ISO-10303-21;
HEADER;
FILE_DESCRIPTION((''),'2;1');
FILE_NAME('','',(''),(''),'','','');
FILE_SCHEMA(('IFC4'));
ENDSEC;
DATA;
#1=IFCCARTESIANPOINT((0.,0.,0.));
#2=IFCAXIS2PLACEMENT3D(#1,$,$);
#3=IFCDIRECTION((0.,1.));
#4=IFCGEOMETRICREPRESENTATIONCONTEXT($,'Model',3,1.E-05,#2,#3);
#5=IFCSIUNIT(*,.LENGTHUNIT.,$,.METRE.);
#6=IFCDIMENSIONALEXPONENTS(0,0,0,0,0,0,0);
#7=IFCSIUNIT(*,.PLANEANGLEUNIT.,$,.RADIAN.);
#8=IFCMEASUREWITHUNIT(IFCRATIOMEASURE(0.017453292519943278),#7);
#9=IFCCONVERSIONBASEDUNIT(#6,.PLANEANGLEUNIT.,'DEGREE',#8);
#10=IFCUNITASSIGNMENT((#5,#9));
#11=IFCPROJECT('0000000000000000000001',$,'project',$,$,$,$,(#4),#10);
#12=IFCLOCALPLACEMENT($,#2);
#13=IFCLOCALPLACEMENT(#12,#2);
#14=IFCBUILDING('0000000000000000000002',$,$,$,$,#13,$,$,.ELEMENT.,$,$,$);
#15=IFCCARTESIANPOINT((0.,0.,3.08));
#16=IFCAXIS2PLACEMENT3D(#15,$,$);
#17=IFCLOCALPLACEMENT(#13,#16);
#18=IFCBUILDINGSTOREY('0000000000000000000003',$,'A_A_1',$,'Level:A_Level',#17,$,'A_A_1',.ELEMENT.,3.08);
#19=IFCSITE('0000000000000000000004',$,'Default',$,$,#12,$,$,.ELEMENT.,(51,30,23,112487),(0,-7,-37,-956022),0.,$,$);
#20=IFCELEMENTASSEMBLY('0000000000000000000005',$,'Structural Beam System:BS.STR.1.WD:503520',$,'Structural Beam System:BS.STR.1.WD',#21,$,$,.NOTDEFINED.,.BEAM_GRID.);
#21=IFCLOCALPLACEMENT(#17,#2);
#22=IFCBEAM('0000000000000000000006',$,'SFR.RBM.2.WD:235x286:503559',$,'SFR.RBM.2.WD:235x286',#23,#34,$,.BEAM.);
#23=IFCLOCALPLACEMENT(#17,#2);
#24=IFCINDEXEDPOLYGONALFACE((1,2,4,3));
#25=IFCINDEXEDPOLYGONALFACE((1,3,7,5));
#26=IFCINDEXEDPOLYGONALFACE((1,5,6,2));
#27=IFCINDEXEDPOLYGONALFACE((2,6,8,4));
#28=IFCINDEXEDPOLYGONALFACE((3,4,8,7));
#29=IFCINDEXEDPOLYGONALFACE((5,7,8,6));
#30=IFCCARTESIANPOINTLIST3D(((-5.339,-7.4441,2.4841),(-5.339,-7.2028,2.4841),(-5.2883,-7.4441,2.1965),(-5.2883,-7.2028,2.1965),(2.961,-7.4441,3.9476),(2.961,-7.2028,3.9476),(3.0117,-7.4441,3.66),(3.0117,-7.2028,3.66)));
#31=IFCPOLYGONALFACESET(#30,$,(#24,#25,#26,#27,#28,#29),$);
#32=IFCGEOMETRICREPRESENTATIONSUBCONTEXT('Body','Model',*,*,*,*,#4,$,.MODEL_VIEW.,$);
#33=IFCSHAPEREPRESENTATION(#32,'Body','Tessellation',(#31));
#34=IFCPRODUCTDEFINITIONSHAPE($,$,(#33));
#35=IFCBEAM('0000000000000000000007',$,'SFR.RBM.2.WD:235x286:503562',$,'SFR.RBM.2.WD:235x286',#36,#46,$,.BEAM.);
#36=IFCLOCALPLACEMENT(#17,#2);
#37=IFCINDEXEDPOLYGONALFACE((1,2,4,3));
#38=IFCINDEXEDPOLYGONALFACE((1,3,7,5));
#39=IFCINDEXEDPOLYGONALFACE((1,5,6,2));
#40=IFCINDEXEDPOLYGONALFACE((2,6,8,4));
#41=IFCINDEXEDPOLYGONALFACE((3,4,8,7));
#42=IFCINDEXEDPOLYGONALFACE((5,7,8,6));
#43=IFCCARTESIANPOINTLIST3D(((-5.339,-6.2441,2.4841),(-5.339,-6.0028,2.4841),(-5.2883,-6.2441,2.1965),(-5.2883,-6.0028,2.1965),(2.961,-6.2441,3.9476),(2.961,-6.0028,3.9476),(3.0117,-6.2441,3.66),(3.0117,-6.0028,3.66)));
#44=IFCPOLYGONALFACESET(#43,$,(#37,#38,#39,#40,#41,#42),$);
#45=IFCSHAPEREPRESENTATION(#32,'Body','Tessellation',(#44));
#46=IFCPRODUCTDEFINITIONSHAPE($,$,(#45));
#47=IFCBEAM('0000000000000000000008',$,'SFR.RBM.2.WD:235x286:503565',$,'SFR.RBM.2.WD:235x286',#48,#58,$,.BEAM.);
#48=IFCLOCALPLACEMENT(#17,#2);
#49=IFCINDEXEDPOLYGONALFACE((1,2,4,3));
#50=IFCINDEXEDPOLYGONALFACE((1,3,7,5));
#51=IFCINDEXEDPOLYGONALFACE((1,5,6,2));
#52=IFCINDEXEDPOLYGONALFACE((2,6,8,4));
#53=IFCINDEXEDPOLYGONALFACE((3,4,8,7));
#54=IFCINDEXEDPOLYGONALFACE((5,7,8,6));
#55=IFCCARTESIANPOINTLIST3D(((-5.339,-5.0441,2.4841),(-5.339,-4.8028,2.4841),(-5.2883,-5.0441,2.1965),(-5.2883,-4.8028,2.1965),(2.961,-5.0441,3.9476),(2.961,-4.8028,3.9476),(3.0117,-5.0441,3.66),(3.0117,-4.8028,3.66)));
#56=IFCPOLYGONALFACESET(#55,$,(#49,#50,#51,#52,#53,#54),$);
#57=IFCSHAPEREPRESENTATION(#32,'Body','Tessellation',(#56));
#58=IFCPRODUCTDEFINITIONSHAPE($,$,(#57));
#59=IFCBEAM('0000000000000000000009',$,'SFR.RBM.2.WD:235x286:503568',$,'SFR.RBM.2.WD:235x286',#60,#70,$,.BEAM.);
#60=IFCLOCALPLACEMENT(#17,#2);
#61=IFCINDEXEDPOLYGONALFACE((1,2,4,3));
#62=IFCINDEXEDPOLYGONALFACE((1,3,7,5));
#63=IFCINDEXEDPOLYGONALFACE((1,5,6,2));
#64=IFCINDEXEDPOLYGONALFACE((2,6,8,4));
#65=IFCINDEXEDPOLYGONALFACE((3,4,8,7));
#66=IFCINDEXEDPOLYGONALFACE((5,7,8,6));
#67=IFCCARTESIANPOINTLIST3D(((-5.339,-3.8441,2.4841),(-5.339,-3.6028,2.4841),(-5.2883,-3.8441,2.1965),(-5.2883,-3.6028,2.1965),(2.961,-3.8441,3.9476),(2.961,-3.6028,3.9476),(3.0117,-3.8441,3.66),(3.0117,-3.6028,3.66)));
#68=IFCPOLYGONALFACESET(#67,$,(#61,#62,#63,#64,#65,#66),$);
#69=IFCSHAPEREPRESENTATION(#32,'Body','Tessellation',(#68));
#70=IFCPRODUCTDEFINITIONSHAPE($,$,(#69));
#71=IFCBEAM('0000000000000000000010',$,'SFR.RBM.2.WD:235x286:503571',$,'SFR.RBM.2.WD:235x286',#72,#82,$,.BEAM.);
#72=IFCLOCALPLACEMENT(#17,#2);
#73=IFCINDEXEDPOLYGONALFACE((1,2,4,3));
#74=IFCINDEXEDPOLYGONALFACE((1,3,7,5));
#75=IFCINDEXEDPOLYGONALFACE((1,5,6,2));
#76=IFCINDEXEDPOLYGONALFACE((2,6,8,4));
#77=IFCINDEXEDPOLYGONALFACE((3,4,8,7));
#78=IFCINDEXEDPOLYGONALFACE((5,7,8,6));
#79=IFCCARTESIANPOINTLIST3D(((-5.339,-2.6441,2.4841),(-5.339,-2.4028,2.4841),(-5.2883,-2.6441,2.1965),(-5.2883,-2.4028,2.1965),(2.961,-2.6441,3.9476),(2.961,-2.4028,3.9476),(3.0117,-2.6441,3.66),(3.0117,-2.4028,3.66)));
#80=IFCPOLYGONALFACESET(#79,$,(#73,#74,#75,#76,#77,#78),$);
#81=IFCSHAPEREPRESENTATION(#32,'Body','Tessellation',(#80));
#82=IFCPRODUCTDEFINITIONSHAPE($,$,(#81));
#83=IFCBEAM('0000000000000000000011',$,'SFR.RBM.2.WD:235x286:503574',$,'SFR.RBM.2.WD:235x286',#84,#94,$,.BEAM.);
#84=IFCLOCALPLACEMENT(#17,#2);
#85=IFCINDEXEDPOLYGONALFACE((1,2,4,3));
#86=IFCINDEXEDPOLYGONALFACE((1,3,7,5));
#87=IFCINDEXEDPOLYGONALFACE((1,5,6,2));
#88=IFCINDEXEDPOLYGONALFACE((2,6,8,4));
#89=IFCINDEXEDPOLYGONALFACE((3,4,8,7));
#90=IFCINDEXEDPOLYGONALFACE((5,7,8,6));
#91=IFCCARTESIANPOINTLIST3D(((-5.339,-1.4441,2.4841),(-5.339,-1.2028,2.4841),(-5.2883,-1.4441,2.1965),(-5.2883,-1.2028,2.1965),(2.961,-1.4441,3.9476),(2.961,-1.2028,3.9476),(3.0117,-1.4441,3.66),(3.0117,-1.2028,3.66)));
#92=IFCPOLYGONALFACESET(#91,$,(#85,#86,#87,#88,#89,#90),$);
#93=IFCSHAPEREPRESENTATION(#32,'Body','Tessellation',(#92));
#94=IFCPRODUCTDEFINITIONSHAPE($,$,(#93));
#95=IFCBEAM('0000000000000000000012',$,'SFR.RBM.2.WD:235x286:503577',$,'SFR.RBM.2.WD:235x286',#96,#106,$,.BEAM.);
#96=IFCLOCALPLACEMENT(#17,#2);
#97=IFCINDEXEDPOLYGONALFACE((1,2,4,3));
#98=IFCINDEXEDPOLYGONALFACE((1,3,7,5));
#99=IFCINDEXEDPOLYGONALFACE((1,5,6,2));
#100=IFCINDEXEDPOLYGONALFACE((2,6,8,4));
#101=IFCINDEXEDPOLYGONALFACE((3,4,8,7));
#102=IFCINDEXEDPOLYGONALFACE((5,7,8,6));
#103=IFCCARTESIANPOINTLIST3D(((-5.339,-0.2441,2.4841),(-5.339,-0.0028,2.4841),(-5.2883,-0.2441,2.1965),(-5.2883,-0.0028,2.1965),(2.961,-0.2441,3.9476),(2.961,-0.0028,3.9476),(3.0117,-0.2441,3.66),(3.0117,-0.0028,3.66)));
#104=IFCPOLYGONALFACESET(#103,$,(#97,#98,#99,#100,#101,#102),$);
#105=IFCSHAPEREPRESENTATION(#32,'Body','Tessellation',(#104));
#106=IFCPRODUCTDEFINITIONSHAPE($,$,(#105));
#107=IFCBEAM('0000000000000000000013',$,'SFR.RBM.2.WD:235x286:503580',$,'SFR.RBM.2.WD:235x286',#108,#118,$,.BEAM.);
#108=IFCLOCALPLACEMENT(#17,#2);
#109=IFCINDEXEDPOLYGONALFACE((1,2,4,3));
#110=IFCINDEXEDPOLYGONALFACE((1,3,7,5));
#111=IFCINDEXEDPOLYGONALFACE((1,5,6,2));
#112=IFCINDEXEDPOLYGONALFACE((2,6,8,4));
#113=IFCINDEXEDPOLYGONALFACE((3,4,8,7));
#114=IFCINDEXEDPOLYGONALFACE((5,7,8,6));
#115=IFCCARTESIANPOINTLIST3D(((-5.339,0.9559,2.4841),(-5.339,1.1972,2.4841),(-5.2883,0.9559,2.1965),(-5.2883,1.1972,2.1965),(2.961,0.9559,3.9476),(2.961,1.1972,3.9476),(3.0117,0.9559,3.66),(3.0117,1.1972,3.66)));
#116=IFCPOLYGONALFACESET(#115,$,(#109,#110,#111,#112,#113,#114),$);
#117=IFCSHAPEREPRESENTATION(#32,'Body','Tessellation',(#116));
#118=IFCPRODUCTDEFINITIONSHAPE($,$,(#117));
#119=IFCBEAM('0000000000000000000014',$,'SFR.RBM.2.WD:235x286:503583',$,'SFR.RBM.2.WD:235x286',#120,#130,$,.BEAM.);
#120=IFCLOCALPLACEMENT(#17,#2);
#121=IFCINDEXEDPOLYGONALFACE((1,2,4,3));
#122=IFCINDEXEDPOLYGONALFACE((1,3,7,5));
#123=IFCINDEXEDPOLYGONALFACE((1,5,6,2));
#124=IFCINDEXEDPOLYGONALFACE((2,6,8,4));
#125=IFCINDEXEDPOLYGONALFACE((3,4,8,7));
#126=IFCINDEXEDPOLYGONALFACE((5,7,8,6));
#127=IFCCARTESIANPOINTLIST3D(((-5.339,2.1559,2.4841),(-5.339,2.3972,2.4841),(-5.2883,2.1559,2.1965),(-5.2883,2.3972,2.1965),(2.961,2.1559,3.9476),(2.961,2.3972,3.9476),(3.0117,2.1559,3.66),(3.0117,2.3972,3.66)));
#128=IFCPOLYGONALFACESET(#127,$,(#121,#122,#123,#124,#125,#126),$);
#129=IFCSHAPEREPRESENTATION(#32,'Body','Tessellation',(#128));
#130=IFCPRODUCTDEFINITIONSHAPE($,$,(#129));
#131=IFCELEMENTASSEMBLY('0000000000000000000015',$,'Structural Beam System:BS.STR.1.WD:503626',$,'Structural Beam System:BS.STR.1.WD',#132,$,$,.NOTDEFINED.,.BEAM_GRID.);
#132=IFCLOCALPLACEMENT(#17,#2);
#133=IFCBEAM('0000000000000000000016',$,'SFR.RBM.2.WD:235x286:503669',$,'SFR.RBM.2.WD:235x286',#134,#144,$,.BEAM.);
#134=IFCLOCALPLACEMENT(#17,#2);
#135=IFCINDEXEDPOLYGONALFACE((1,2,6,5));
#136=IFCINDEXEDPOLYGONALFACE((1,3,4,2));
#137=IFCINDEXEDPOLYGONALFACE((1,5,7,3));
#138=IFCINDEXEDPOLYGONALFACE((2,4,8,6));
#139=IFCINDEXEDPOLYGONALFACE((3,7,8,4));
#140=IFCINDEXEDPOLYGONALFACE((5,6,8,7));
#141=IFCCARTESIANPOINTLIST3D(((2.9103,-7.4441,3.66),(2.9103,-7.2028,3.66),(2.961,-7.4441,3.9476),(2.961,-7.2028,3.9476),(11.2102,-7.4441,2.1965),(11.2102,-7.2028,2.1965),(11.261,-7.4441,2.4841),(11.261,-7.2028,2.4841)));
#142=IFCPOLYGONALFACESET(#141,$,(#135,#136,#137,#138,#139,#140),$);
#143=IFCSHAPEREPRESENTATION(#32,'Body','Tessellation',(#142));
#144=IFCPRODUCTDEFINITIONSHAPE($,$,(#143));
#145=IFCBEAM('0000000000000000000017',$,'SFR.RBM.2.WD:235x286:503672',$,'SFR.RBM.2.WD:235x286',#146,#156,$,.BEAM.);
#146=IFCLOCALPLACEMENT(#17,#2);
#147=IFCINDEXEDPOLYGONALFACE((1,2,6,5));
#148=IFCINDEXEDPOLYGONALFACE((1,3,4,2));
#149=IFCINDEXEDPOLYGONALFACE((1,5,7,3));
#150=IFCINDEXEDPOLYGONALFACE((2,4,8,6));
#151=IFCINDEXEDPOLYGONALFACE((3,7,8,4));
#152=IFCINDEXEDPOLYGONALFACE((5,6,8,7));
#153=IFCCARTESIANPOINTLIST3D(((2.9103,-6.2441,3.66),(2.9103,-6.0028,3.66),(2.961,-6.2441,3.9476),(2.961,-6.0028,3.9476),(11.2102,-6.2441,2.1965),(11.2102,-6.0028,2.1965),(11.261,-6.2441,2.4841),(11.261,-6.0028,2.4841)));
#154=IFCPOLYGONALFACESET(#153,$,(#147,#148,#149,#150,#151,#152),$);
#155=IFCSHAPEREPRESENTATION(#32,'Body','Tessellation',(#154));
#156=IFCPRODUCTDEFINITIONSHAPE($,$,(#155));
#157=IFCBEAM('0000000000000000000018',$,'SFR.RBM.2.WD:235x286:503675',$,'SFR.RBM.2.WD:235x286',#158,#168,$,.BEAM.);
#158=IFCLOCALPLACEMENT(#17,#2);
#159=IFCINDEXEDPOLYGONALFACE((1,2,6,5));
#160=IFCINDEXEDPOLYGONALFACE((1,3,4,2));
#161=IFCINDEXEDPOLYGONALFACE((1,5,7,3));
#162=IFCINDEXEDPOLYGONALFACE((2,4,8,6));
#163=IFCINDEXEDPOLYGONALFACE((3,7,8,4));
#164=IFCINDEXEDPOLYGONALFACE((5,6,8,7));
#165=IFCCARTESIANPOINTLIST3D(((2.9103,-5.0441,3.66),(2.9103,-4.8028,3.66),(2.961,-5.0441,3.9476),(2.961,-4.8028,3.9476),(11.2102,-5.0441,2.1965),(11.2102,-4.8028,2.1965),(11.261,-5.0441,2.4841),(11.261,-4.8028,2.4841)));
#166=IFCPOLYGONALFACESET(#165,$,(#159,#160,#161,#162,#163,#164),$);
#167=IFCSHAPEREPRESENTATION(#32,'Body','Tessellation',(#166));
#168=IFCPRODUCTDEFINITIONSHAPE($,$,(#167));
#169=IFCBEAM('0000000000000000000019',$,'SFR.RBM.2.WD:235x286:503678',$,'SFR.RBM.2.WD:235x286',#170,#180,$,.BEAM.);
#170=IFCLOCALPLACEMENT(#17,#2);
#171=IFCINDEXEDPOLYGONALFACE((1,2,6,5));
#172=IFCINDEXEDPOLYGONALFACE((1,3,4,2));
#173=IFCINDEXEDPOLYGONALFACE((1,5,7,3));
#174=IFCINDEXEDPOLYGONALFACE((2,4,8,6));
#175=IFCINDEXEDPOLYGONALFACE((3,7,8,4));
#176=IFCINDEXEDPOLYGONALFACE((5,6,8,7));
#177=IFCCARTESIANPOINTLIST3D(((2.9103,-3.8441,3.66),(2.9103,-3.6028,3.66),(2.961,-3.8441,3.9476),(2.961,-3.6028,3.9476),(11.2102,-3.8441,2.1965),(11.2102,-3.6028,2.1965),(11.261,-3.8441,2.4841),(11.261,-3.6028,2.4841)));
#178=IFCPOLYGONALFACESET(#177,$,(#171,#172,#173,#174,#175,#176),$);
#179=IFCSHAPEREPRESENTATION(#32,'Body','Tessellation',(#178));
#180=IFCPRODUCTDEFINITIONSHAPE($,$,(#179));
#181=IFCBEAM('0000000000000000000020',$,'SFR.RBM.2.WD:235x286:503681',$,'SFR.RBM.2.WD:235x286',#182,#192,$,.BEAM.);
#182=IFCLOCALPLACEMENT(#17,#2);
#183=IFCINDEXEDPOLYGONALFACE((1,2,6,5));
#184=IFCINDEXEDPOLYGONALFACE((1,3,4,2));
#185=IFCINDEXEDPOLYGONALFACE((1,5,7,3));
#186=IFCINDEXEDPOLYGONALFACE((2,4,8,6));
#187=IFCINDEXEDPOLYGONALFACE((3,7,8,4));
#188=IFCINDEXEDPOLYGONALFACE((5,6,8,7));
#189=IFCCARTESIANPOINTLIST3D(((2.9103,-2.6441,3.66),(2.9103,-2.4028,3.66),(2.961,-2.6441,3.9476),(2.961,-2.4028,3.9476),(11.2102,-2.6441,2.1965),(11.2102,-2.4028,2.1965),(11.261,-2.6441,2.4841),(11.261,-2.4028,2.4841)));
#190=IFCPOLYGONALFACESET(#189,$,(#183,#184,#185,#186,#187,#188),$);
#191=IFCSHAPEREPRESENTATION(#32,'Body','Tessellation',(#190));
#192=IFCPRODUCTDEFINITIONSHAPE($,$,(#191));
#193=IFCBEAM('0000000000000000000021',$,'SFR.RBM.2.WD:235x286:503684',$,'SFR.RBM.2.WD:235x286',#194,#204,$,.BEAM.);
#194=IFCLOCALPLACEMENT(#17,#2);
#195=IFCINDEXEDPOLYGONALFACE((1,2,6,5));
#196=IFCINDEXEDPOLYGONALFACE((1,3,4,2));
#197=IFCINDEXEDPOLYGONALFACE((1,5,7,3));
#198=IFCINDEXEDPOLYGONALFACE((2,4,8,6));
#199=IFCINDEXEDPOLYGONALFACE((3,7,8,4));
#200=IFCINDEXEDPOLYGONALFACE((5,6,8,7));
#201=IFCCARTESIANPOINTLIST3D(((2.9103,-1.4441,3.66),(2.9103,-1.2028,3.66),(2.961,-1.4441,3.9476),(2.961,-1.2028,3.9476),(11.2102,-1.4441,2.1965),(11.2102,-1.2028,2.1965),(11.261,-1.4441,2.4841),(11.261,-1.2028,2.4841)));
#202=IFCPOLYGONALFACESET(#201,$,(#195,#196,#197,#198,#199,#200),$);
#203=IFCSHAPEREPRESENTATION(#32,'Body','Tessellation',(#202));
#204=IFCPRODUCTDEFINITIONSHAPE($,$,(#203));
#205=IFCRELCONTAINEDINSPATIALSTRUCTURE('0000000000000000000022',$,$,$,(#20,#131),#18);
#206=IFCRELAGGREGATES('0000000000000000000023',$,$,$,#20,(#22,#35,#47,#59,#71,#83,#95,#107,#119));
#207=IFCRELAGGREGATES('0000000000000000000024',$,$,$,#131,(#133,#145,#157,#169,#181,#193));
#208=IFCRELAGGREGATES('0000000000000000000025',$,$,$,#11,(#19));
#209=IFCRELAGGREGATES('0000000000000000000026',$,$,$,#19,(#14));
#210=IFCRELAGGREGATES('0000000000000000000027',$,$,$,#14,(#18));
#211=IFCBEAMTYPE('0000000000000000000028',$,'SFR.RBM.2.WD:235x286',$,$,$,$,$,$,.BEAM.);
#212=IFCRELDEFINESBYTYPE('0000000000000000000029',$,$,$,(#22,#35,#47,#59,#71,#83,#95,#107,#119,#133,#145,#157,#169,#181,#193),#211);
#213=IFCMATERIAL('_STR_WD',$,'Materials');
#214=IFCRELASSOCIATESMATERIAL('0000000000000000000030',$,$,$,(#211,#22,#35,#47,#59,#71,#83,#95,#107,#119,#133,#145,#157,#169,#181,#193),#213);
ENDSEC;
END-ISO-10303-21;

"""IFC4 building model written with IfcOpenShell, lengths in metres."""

from ifc_helpers import new_model, entity, si_unit, converted_unit, direction, frame, origin, place, context, subcontext, project, spatial, indexed_curve, outline, extrude, source, transform, mapped, material, type_object, type_shapes, element, aggregate, save


model = new_model("IFC4")

# Units and contexts
model_context = context("Model", 3, precision=1e-05, world=origin(), true_north=direction((0.0, 1.0)))
body_context = subcontext(model_context, "Body", "Model", "MODEL_VIEW")
ifc_project = project(units=[si_unit("LENGTHUNIT", "METRE"), converted_unit("PLANEANGLEUNIT", "DEGREE", entity("IfcRatioMeasure", 0.017453292519943278), si_unit("PLANEANGLEUNIT", "RADIAN"), dimensions=[0, 0, 0, 0, 0, 0, 0])], contexts=[model_context])

# Site, building, storey
site_placement = place(None, origin())
site = spatial("IfcSite", under=ifc_project, at=site_placement, Name="Default", CompositionType="ELEMENT", RefLatitude=(51, 30, 23, 112487), RefLongitude=(0, -7, -37, -956022), RefElevation=0.0)
building_placement = place(site_placement, origin())
building = spatial("IfcBuilding", under=site, at=building_placement, CompositionType="ELEMENT")
storey_placement = place(building_placement, frame((0.0, 0.0, 3.08)))
storey = spatial("IfcBuildingStorey", under=building, at=storey_placement, Name="A_A_1", ObjectType="Level:A_Level", LongName="A_A_1", CompositionType="ELEMENT", Elevation=3.08)

# Element assemblies, beams
assembly_1_placement = place(storey_placement, origin())
assembly_1 = element("IfcElementAssembly", 1, at=assembly_1_placement, inside=storey, Name="Structural Beam System:BS.STR.1.WD:503520", ObjectType="Structural Beam System:BS.STR.1.WD", AssemblyPlace="NOTDEFINED", PredefinedType="BEAM_GRID")
ifc_material_1 = material(Name="_STR_WD", Category="Materials")
beam_type = type_object("IfcBeamType", Name="SFR.RBM.2.WD:235x286", PredefinedType="BEAM", material=ifc_material_1)
shared_shape = source(origin(), body_context, "Body", "SweptSolid", [
    extrude(outline(indexed_curve([(-0.146, -0.1207), (0.146, -0.1207), (0.146, 0.1207), (-0.146, 0.1207), (-0.146, -0.1207)], self_intersect=False)), frame((-4.214, 0.0, 0.0), z_axis=(1.0, 0.0, 0.0), x_axis=(0.0, 0.0, -1.0)), (0.0, 0.0, 1.0), 8.428),
])
type_shapes(beam_type, [shared_shape])
beam_1_placement = place(assembly_1_placement, frame((-1.1636, -7.3235, 3.072), z_axis=(-0.173648, 0.0, 0.984808), x_axis=(0.984808, 0.0, 0.173648)))
beam_1 = element("IfcBeam", 2, at=beam_1_placement, type_object=beam_type, material=ifc_material_1, Name="SFR.RBM.2.WD:235x286:503559", ObjectType="SFR.RBM.2.WD:235x286", PredefinedType="BEAM", context=body_context, shape_type="MappedRepresentation", body=[
    mapped(shared_shape, transform((0.0, 0.0, 0.0), scale=1.0)),
])
beam_2_placement = place(assembly_1_placement, frame((-1.1636, -6.1235, 3.072), z_axis=(-0.173648, 0.0, 0.984808), x_axis=(0.984808, 0.0, 0.173648)))
beam_2 = element("IfcBeam", 3, at=beam_2_placement, type_object=beam_type, material=ifc_material_1, Name="SFR.RBM.2.WD:235x286:503562", ObjectType="SFR.RBM.2.WD:235x286", PredefinedType="BEAM", context=body_context, shape_type="MappedRepresentation", body=[
    mapped(shared_shape, transform((0.0, 0.0, 0.0), scale=1.0)),
])
beam_3_placement = place(assembly_1_placement, frame((-1.1636, -4.9235, 3.072), z_axis=(-0.173648, 0.0, 0.984808), x_axis=(0.984808, 0.0, 0.173648)))
beam_3 = element("IfcBeam", 4, at=beam_3_placement, type_object=beam_type, material=ifc_material_1, Name="SFR.RBM.2.WD:235x286:503565", ObjectType="SFR.RBM.2.WD:235x286", PredefinedType="BEAM", context=body_context, shape_type="MappedRepresentation", body=[
    mapped(shared_shape, transform((0.0, 0.0, 0.0), scale=1.0)),
])
beam_4_placement = place(assembly_1_placement, frame((-1.1636, -3.7235, 3.072), z_axis=(-0.173648, 0.0, 0.984808), x_axis=(0.984808, 0.0, 0.173648)))
beam_4 = element("IfcBeam", 5, at=beam_4_placement, type_object=beam_type, material=ifc_material_1, Name="SFR.RBM.2.WD:235x286:503568", ObjectType="SFR.RBM.2.WD:235x286", PredefinedType="BEAM", context=body_context, shape_type="MappedRepresentation", body=[
    mapped(shared_shape, transform((0.0, 0.0, 0.0), scale=1.0)),
])
beam_5_placement = place(assembly_1_placement, frame((-1.1636, -2.5235, 3.072), z_axis=(-0.173648, 0.0, 0.984808), x_axis=(0.984808, 0.0, 0.173648)))
beam_5 = element("IfcBeam", 6, at=beam_5_placement, type_object=beam_type, material=ifc_material_1, Name="SFR.RBM.2.WD:235x286:503571", ObjectType="SFR.RBM.2.WD:235x286", PredefinedType="BEAM", context=body_context, shape_type="MappedRepresentation", body=[
    mapped(shared_shape, transform((0.0, 0.0, 0.0), scale=1.0)),
])
beam_6_placement = place(assembly_1_placement, frame((-1.1636, -1.3235, 3.072), z_axis=(-0.173648, 0.0, 0.984808), x_axis=(0.984808, 0.0, 0.173648)))
beam_6 = element("IfcBeam", 7, at=beam_6_placement, type_object=beam_type, material=ifc_material_1, Name="SFR.RBM.2.WD:235x286:503574", ObjectType="SFR.RBM.2.WD:235x286", PredefinedType="BEAM", context=body_context, shape_type="MappedRepresentation", body=[
    mapped(shared_shape, transform((0.0, 0.0, 0.0), scale=1.0)),
])
beam_7_placement = place(assembly_1_placement, frame((-1.1636, -0.1235, 3.072), z_axis=(-0.173648, 0.0, 0.984808), x_axis=(0.984808, 0.0, 0.173648)))
beam_7 = element("IfcBeam", 8, at=beam_7_placement, type_object=beam_type, material=ifc_material_1, Name="SFR.RBM.2.WD:235x286:503577", ObjectType="SFR.RBM.2.WD:235x286", PredefinedType="BEAM", context=body_context, shape_type="MappedRepresentation", body=[
    mapped(shared_shape, transform((0.0, 0.0, 0.0), scale=1.0)),
])
beam_8_placement = place(assembly_1_placement, frame((-1.1636, 1.0765, 3.072), z_axis=(-0.173648, 0.0, 0.984808), x_axis=(0.984808, 0.0, 0.173648)))
beam_8 = element("IfcBeam", 9, at=beam_8_placement, type_object=beam_type, material=ifc_material_1, Name="SFR.RBM.2.WD:235x286:503580", ObjectType="SFR.RBM.2.WD:235x286", PredefinedType="BEAM", context=body_context, shape_type="MappedRepresentation", body=[
    mapped(shared_shape, transform((0.0, 0.0, 0.0), scale=1.0)),
])
beam_9_placement = place(assembly_1_placement, frame((-1.1636, 2.2765, 3.072), z_axis=(-0.173648, 0.0, 0.984808), x_axis=(0.984808, 0.0, 0.173648)))
beam_9 = element("IfcBeam", 10, at=beam_9_placement, type_object=beam_type, material=ifc_material_1, Name="SFR.RBM.2.WD:235x286:503583", ObjectType="SFR.RBM.2.WD:235x286", PredefinedType="BEAM", context=body_context, shape_type="MappedRepresentation", body=[
    mapped(shared_shape, transform((0.0, 0.0, 0.0), scale=1.0)),
])
aggregate(assembly_1, [beam_1, beam_2, beam_3, beam_4, beam_5, beam_6, beam_7, beam_8, beam_9])
assembly_2_placement = place(storey_placement, origin())
assembly_2 = element("IfcElementAssembly", 11, at=assembly_2_placement, inside=storey, Name="Structural Beam System:BS.STR.1.WD:503626", ObjectType="Structural Beam System:BS.STR.1.WD", AssemblyPlace="NOTDEFINED", PredefinedType="BEAM_GRID")
beam_10_placement = place(assembly_2_placement, frame((7.0856, -7.3235, 3.072), z_axis=(0.173648, 0.0, 0.984808), x_axis=(0.984808, 0.0, -0.173648)))
beam_10 = element("IfcBeam", 12, at=beam_10_placement, type_object=beam_type, material=ifc_material_1, Name="SFR.RBM.2.WD:235x286:503669", ObjectType="SFR.RBM.2.WD:235x286", PredefinedType="BEAM", context=body_context, shape_type="MappedRepresentation", body=[
    mapped(shared_shape, transform((0.0, 0.0, 0.0), scale=1.0)),
])
beam_11_placement = place(assembly_2_placement, frame((7.0856, -6.1235, 3.072), z_axis=(0.173648, 0.0, 0.984808), x_axis=(0.984808, 0.0, -0.173648)))
beam_11 = element("IfcBeam", 13, at=beam_11_placement, type_object=beam_type, material=ifc_material_1, Name="SFR.RBM.2.WD:235x286:503672", ObjectType="SFR.RBM.2.WD:235x286", PredefinedType="BEAM", context=body_context, shape_type="MappedRepresentation", body=[
    mapped(shared_shape, transform((0.0, 0.0, 0.0), scale=1.0)),
])
beam_12_placement = place(assembly_2_placement, frame((7.0856, -4.9235, 3.072), z_axis=(0.173648, 0.0, 0.984808), x_axis=(0.984808, 0.0, -0.173648)))
beam_12 = element("IfcBeam", 14, at=beam_12_placement, type_object=beam_type, material=ifc_material_1, Name="SFR.RBM.2.WD:235x286:503675", ObjectType="SFR.RBM.2.WD:235x286", PredefinedType="BEAM", context=body_context, shape_type="MappedRepresentation", body=[
    mapped(shared_shape, transform((0.0, 0.0, 0.0), scale=1.0)),
])
beam_13_placement = place(assembly_2_placement, frame((7.0856, -3.7235, 3.072), z_axis=(0.173648, 0.0, 0.984808), x_axis=(0.984808, 0.0, -0.173648)))
beam_13 = element("IfcBeam", 15, at=beam_13_placement, type_object=beam_type, material=ifc_material_1, Name="SFR.RBM.2.WD:235x286:503678", ObjectType="SFR.RBM.2.WD:235x286", PredefinedType="BEAM", context=body_context, shape_type="MappedRepresentation", body=[
    mapped(shared_shape, transform((0.0, 0.0, 0.0), scale=1.0)),
])
beam_14_placement = place(assembly_2_placement, frame((7.0856, -2.5235, 3.072), z_axis=(0.173648, 0.0, 0.984808), x_axis=(0.984808, 0.0, -0.173648)))
beam_14 = element("IfcBeam", 16, at=beam_14_placement, type_object=beam_type, material=ifc_material_1, Name="SFR.RBM.2.WD:235x286:503681", ObjectType="SFR.RBM.2.WD:235x286", PredefinedType="BEAM", context=body_context, shape_type="MappedRepresentation", body=[
    mapped(shared_shape, transform((0.0, 0.0, 0.0), scale=1.0)),
])
beam_15_placement = place(assembly_2_placement, frame((7.0856, -1.3235, 3.072), z_axis=(0.173648, 0.0, 0.984808), x_axis=(0.984808, 0.0, -0.173648)))
beam_15 = element("IfcBeam", 17, at=beam_15_placement, type_object=beam_type, material=ifc_material_1, Name="SFR.RBM.2.WD:235x286:503684", ObjectType="SFR.RBM.2.WD:235x286", PredefinedType="BEAM", context=body_context, shape_type="MappedRepresentation", body=[
    mapped(shared_shape, transform((0.0, 0.0, 0.0), scale=1.0)),
])
aggregate(assembly_2, [beam_10, beam_11, beam_12, beam_13, beam_14, beam_15])

save(model, "model.ifc")
